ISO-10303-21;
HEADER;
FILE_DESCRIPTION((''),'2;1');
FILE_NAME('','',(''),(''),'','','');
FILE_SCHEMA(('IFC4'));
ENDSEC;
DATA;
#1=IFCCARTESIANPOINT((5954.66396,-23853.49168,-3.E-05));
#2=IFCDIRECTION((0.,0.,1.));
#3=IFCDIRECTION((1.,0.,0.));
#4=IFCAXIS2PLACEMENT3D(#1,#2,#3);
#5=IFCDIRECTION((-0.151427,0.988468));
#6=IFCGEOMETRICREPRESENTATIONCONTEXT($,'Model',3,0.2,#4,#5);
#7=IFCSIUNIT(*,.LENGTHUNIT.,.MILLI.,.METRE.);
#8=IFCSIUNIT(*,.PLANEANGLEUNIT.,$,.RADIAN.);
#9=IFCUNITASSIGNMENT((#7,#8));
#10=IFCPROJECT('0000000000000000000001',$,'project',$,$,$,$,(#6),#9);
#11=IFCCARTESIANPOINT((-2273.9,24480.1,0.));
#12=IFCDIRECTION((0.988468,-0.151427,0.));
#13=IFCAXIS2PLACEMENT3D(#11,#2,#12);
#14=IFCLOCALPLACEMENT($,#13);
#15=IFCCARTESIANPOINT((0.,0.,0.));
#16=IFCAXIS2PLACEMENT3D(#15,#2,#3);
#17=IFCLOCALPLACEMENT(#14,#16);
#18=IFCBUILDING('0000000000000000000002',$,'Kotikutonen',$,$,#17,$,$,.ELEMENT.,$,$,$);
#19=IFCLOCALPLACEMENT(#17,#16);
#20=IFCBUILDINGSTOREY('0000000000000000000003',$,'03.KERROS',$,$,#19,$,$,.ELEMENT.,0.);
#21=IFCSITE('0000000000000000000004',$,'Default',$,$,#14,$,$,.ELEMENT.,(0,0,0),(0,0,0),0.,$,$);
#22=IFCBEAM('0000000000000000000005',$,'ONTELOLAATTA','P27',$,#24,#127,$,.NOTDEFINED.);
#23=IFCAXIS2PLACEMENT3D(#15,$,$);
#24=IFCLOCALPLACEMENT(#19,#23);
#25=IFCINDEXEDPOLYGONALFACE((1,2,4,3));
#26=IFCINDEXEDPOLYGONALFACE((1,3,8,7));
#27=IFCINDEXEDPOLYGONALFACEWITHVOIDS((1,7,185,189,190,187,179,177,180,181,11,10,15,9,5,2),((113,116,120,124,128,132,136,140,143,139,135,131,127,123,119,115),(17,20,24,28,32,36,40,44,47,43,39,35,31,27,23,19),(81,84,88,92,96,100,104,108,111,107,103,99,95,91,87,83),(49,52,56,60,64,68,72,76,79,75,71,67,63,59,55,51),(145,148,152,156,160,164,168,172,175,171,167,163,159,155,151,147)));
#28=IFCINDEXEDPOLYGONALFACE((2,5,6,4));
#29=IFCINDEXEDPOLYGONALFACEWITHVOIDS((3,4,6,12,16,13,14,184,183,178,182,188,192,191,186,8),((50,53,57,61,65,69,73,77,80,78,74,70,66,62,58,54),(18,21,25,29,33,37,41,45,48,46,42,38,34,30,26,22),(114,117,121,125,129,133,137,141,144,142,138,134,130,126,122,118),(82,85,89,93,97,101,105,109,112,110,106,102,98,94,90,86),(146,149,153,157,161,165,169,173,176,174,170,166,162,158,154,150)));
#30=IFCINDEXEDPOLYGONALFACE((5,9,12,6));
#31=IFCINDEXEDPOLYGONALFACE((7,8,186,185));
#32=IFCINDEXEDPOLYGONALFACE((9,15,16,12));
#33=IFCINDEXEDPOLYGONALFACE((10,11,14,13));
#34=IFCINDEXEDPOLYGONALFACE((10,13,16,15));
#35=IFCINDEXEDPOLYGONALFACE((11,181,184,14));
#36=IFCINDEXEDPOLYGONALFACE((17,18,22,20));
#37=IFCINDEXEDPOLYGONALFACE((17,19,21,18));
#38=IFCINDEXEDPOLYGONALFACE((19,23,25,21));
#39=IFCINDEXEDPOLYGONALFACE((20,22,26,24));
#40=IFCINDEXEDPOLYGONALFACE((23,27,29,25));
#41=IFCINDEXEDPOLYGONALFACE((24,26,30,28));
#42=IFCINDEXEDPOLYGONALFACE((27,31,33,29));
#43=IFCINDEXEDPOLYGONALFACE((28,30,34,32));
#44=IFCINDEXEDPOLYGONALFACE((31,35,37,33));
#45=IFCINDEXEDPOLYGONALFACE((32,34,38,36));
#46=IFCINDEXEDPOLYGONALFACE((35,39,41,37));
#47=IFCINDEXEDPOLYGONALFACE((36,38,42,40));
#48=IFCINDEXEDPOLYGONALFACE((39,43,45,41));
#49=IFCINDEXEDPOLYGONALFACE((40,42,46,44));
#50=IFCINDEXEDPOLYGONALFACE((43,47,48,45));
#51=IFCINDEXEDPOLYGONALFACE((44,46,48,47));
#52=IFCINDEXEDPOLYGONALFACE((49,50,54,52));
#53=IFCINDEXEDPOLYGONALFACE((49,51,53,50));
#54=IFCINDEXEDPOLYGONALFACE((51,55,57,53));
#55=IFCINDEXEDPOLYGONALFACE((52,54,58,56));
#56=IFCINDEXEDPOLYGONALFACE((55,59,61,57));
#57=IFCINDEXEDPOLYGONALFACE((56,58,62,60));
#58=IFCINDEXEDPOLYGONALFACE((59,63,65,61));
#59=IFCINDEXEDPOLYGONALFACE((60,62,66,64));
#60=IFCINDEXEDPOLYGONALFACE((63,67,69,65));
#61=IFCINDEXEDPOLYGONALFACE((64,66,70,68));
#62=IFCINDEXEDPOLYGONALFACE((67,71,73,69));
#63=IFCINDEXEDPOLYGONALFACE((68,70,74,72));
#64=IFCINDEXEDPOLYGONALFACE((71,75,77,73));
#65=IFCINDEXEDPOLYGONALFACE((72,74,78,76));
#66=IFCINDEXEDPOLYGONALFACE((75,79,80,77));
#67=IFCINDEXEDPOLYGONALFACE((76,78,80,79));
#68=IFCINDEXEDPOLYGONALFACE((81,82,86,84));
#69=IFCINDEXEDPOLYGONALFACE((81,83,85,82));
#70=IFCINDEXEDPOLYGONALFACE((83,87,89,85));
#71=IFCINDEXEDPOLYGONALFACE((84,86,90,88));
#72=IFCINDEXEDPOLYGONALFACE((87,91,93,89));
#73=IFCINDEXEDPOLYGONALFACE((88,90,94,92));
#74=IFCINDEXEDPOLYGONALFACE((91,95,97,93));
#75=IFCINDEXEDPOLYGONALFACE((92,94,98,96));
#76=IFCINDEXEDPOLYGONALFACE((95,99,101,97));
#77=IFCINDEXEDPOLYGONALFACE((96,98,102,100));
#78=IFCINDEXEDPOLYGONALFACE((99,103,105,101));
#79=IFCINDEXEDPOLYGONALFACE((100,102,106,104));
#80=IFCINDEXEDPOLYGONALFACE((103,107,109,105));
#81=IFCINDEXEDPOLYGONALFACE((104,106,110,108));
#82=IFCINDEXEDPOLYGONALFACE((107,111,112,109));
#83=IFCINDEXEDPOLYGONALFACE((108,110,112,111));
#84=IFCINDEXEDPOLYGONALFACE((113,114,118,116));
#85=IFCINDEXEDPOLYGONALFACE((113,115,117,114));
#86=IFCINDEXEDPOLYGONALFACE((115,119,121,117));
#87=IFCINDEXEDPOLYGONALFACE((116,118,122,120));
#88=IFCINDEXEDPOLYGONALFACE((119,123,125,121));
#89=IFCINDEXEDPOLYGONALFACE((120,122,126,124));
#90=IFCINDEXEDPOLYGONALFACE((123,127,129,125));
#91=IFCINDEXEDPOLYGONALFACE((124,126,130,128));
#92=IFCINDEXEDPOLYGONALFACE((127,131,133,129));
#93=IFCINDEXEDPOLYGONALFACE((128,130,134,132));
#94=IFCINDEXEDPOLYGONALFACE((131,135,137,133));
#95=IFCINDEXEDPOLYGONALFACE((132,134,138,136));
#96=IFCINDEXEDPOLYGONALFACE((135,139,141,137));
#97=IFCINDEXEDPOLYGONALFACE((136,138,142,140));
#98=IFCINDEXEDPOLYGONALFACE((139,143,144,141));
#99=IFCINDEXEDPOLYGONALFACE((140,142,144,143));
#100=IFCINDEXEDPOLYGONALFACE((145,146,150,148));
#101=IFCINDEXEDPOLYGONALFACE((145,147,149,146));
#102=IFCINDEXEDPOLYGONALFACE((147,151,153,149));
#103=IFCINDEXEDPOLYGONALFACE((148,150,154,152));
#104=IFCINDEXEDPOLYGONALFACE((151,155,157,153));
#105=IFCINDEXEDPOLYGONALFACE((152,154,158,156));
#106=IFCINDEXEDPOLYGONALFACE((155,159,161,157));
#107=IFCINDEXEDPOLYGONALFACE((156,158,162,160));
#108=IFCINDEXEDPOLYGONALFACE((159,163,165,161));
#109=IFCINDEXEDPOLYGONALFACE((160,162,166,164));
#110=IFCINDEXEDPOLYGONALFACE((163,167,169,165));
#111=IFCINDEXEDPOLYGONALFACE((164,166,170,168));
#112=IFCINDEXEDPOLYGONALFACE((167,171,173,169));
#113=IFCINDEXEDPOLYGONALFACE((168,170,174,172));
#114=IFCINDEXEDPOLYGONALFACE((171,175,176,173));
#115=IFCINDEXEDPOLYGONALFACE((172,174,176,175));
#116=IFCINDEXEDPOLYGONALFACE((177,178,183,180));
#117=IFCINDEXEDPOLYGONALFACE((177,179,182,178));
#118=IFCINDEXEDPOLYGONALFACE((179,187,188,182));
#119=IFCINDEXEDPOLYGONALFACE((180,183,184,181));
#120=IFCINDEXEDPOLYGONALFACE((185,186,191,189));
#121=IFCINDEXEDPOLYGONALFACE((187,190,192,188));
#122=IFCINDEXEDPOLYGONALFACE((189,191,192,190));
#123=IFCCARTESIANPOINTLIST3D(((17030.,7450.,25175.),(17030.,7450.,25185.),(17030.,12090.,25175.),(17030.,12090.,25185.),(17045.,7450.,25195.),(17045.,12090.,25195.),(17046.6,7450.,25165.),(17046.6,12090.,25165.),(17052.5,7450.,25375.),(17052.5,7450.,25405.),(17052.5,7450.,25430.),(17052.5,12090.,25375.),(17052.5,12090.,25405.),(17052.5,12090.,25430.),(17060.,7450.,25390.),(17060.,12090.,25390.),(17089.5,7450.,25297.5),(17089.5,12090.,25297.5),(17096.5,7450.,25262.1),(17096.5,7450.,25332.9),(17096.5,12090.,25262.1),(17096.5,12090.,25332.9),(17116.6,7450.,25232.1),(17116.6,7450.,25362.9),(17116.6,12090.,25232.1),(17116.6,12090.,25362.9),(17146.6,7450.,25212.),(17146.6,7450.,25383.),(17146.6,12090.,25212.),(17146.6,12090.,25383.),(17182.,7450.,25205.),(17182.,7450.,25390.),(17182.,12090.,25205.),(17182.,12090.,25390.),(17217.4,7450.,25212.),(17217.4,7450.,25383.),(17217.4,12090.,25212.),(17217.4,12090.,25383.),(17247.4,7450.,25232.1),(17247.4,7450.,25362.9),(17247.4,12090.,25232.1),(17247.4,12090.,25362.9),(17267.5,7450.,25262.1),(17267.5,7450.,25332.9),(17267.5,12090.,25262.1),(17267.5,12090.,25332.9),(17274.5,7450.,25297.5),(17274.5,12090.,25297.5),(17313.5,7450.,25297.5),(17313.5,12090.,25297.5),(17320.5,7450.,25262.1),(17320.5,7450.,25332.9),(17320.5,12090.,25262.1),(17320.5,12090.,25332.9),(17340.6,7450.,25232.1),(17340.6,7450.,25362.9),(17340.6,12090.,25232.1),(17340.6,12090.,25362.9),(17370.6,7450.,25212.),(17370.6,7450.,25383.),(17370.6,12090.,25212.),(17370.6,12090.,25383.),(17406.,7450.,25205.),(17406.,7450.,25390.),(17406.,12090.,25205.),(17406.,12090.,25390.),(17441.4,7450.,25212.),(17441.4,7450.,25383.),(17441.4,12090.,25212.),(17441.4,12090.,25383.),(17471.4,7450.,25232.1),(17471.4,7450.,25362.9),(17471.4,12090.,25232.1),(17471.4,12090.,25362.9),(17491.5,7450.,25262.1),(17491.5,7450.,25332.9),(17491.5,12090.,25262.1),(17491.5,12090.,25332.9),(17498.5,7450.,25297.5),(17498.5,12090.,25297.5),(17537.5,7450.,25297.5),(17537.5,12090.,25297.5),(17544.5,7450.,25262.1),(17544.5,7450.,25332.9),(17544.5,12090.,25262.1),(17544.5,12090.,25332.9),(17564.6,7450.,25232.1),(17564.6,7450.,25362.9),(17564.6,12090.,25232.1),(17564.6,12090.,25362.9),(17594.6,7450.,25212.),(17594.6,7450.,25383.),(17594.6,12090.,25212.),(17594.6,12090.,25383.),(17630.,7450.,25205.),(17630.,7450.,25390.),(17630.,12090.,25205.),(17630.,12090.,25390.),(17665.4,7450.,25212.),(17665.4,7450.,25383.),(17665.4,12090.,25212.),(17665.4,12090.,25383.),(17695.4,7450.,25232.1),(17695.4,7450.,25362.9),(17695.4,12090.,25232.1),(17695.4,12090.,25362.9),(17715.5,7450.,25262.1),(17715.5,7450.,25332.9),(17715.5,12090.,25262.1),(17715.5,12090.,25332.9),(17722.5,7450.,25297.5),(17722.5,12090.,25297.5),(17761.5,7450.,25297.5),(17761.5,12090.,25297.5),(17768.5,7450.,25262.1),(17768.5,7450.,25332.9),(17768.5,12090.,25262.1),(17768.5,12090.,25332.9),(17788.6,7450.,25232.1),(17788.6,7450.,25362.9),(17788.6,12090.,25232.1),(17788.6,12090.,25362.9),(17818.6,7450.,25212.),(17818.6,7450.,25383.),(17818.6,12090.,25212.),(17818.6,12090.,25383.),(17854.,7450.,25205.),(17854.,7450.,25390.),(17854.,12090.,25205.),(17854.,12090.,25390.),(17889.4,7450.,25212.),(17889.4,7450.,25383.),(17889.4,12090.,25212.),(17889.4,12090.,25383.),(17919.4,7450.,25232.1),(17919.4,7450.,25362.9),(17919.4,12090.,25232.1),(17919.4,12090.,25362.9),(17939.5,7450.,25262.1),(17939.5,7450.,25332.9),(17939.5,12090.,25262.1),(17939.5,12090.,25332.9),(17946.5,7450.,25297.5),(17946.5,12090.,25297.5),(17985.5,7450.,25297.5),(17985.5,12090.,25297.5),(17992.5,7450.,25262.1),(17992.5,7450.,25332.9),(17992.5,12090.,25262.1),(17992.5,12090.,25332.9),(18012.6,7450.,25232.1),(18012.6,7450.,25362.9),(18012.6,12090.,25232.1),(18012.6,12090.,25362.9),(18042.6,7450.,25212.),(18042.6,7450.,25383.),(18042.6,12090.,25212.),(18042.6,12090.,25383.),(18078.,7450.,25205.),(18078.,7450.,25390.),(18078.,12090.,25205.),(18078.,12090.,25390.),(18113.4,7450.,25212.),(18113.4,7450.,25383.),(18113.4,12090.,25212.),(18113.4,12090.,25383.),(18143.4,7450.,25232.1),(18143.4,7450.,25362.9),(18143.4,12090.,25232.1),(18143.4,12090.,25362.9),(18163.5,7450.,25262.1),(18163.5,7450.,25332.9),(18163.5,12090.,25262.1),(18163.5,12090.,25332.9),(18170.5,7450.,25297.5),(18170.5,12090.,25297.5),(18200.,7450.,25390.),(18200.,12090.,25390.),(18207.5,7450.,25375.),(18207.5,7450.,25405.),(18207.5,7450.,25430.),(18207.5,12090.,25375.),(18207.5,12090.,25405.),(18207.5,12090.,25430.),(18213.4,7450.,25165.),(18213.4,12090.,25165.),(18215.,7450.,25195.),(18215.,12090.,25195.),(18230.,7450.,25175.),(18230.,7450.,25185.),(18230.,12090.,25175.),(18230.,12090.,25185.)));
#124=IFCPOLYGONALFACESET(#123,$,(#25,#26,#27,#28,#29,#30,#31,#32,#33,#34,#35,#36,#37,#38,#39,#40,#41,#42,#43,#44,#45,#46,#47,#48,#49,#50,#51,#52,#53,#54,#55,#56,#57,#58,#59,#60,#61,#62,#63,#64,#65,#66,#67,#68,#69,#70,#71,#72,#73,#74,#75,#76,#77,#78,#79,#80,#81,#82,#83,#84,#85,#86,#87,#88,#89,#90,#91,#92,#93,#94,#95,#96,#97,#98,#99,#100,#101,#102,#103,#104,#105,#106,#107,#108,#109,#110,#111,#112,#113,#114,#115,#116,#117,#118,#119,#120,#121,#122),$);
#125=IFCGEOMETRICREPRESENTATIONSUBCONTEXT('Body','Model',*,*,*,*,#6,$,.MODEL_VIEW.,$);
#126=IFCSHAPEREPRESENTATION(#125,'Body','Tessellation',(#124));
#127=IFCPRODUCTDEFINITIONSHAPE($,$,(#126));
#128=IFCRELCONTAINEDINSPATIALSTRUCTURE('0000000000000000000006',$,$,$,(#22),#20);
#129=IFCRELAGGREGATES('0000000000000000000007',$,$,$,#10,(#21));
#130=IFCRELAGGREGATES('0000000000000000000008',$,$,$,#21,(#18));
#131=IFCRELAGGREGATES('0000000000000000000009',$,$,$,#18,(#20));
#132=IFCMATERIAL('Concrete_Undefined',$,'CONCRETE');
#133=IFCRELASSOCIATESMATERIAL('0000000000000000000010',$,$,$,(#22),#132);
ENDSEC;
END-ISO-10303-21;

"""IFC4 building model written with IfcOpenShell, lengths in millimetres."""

from ifc_helpers import new_model, si_unit, direction, frame, origin_with_axes, place, context, subcontext, project, spatial, line, indexed_curve, outline, extrude, material, element, save


model = new_model("IFC4")

# Units and contexts
model_context = context("Model", 3, precision=0.2, world=frame((5954.66396, -23853.49168, -3e-05), z_axis=(0.0, 0.0, 1.0), x_axis=(1.0, 0.0, 0.0)), true_north=direction((-0.151427, 0.988468)))
body_context = subcontext(model_context, "Body", "Model", "MODEL_VIEW")
ifc_project = project(units=[si_unit("LENGTHUNIT", "METRE", prefix="MILLI"), si_unit("PLANEANGLEUNIT", "RADIAN")], contexts=[model_context])

# Site, building, storey
site_placement = place(None, frame((-2273.9, 24480.1, 0.0), z_axis=(0.0, 0.0, 1.0), x_axis=(0.988468, -0.151427, 0.0)))
site = spatial("IfcSite", under=ifc_project, at=site_placement, Name="Default", CompositionType="ELEMENT", RefLatitude=(0, 0, 0), RefLongitude=(0, 0, 0), RefElevation=0.0)
building_placement = place(site_placement, origin_with_axes())
building = spatial("IfcBuilding", under=site, at=building_placement, Name="Kotikutonen", CompositionType="ELEMENT")
storey_placement = place(building_placement, origin_with_axes())
storey = spatial("IfcBuildingStorey", under=building, at=storey_placement, Name="03.KERROS", CompositionType="ELEMENT", Elevation=0.0)

# Shared definitions
ifc_material_1 = material(Name="Concrete_Undefined", Category="CONCRETE")

# Beam
beam_1_placement = place(storey_placement, frame((17630.0, 12090.0, 25297.5), z_axis=(-1.0, 0.0, 0.0), x_axis=(0.0, -1.0, 0.0)))
element("IfcBeam", 1, at=beam_1_placement, inside=storey, material=ifc_material_1, Name="ONTELOLAATTA", Description="P27", PredefinedType="NOTDEFINED", context=body_context, shape_type="SolidModel", body=[
    extrude(outline(indexed_curve([(-600.0, -122.5), (-583.4, -132.5), (583.4, -132.5), (600.0, -122.5), (600.0, -112.5), (585.0, -102.5), (577.5, 77.5), (570.0, 92.5), (577.5, 107.5), (577.5, 132.5), (-577.5, 132.5), (-577.5, 107.5), (-570.0, 92.5), (-577.5, 77.5), (-585.0, -102.5), (-600.0, -112.5)], segments=[line(1, 2, 3, 4, 5, 6, 7, 8, 9, 10, 11, 12, 13, 14, 15, 16, 1)]), holes=[indexed_curve([(-448.0, -92.5), (-483.4, -85.5), (-513.4, -65.4), (-533.5, -35.4), (-540.5, 0.0), (-533.5, 35.4), (-513.4, 65.4), (-483.4, 85.5), (-448.0, 92.5), (-412.6, 85.5), (-382.6, 65.4), (-362.5, 35.4), (-355.5, 0.0), (-362.5, -35.4), (-382.6, -65.4), (-412.6, -85.5)], segments=[line(1, 2, 3, 4, 5, 6, 7, 8, 9, 10, 11, 12, 13, 14, 15, 16, 1)]), indexed_curve([(-224.0, -92.5), (-259.4, -85.5), (-289.4, -65.4), (-309.5, -35.4), (-316.5, 0.0), (-309.5, 35.4), (-289.4, 65.4), (-259.4, 85.5), (-224.0, 92.5), (-188.6, 85.5), (-158.6, 65.4), (-138.5, 35.4), (-131.5, 0.0), (-138.5, -35.4), (-158.6, -65.4), (-188.6, -85.5)], segments=[line(1, 2, 3, 4, 5, 6, 7, 8, 9, 10, 11, 12, 13, 14, 15, 16, 1)]), indexed_curve([(0.0, -92.5), (-35.4, -85.5), (-65.4, -65.4), (-85.5, -35.4), (-92.5, 0.0), (-85.5, 35.4), (-65.4, 65.4), (-35.4, 85.5), (0.0, 92.5), (35.4, 85.5), (65.4, 65.4), (85.5, 35.4), (92.5, 0.0), (85.5, -35.4), (65.4, -65.4), (35.4, -85.5)], segments=[line(1, 2, 3, 4, 5, 6, 7, 8, 9, 10, 11, 12, 13, 14, 15, 16, 1)]), indexed_curve([(224.0, -92.5), (188.6, -85.5), (158.6, -65.4), (138.5, -35.4), (131.5, 0.0), (138.5, 35.4), (158.6, 65.4), (188.6, 85.5), (224.0, 92.5), (259.4, 85.5), (289.4, 65.4), (309.5, 35.4), (316.5, 0.0), (309.5, -35.4), (289.4, -65.4), (259.4, -85.5)], segments=[line(1, 2, 3, 4, 5, 6, 7, 8, 9, 10, 11, 12, 13, 14, 15, 16, 1)]), indexed_curve([(448.0, -92.5), (412.6, -85.5), (382.6, -65.4), (362.5, -35.4), (355.5, 0.0), (362.5, 35.4), (382.6, 65.4), (412.6, 85.5), (448.0, 92.5), (483.4, 85.5), (513.4, 65.4), (533.5, 35.4), (540.5, 0.0), (533.5, -35.4), (513.4, -65.4), (483.4, -85.5)], segments=[line(1, 2, 3, 4, 5, 6, 7, 8, 9, 10, 11, 12, 13, 14, 15, 16, 1)])]), frame((0.0, 0.0, 0.0), z_axis=(-1.0, 0.0, 0.0), x_axis=(0.0, 0.0, 1.0)), (0.0, 0.0, -1.0), 4640.0),
])

save(model, "model.ifc")
